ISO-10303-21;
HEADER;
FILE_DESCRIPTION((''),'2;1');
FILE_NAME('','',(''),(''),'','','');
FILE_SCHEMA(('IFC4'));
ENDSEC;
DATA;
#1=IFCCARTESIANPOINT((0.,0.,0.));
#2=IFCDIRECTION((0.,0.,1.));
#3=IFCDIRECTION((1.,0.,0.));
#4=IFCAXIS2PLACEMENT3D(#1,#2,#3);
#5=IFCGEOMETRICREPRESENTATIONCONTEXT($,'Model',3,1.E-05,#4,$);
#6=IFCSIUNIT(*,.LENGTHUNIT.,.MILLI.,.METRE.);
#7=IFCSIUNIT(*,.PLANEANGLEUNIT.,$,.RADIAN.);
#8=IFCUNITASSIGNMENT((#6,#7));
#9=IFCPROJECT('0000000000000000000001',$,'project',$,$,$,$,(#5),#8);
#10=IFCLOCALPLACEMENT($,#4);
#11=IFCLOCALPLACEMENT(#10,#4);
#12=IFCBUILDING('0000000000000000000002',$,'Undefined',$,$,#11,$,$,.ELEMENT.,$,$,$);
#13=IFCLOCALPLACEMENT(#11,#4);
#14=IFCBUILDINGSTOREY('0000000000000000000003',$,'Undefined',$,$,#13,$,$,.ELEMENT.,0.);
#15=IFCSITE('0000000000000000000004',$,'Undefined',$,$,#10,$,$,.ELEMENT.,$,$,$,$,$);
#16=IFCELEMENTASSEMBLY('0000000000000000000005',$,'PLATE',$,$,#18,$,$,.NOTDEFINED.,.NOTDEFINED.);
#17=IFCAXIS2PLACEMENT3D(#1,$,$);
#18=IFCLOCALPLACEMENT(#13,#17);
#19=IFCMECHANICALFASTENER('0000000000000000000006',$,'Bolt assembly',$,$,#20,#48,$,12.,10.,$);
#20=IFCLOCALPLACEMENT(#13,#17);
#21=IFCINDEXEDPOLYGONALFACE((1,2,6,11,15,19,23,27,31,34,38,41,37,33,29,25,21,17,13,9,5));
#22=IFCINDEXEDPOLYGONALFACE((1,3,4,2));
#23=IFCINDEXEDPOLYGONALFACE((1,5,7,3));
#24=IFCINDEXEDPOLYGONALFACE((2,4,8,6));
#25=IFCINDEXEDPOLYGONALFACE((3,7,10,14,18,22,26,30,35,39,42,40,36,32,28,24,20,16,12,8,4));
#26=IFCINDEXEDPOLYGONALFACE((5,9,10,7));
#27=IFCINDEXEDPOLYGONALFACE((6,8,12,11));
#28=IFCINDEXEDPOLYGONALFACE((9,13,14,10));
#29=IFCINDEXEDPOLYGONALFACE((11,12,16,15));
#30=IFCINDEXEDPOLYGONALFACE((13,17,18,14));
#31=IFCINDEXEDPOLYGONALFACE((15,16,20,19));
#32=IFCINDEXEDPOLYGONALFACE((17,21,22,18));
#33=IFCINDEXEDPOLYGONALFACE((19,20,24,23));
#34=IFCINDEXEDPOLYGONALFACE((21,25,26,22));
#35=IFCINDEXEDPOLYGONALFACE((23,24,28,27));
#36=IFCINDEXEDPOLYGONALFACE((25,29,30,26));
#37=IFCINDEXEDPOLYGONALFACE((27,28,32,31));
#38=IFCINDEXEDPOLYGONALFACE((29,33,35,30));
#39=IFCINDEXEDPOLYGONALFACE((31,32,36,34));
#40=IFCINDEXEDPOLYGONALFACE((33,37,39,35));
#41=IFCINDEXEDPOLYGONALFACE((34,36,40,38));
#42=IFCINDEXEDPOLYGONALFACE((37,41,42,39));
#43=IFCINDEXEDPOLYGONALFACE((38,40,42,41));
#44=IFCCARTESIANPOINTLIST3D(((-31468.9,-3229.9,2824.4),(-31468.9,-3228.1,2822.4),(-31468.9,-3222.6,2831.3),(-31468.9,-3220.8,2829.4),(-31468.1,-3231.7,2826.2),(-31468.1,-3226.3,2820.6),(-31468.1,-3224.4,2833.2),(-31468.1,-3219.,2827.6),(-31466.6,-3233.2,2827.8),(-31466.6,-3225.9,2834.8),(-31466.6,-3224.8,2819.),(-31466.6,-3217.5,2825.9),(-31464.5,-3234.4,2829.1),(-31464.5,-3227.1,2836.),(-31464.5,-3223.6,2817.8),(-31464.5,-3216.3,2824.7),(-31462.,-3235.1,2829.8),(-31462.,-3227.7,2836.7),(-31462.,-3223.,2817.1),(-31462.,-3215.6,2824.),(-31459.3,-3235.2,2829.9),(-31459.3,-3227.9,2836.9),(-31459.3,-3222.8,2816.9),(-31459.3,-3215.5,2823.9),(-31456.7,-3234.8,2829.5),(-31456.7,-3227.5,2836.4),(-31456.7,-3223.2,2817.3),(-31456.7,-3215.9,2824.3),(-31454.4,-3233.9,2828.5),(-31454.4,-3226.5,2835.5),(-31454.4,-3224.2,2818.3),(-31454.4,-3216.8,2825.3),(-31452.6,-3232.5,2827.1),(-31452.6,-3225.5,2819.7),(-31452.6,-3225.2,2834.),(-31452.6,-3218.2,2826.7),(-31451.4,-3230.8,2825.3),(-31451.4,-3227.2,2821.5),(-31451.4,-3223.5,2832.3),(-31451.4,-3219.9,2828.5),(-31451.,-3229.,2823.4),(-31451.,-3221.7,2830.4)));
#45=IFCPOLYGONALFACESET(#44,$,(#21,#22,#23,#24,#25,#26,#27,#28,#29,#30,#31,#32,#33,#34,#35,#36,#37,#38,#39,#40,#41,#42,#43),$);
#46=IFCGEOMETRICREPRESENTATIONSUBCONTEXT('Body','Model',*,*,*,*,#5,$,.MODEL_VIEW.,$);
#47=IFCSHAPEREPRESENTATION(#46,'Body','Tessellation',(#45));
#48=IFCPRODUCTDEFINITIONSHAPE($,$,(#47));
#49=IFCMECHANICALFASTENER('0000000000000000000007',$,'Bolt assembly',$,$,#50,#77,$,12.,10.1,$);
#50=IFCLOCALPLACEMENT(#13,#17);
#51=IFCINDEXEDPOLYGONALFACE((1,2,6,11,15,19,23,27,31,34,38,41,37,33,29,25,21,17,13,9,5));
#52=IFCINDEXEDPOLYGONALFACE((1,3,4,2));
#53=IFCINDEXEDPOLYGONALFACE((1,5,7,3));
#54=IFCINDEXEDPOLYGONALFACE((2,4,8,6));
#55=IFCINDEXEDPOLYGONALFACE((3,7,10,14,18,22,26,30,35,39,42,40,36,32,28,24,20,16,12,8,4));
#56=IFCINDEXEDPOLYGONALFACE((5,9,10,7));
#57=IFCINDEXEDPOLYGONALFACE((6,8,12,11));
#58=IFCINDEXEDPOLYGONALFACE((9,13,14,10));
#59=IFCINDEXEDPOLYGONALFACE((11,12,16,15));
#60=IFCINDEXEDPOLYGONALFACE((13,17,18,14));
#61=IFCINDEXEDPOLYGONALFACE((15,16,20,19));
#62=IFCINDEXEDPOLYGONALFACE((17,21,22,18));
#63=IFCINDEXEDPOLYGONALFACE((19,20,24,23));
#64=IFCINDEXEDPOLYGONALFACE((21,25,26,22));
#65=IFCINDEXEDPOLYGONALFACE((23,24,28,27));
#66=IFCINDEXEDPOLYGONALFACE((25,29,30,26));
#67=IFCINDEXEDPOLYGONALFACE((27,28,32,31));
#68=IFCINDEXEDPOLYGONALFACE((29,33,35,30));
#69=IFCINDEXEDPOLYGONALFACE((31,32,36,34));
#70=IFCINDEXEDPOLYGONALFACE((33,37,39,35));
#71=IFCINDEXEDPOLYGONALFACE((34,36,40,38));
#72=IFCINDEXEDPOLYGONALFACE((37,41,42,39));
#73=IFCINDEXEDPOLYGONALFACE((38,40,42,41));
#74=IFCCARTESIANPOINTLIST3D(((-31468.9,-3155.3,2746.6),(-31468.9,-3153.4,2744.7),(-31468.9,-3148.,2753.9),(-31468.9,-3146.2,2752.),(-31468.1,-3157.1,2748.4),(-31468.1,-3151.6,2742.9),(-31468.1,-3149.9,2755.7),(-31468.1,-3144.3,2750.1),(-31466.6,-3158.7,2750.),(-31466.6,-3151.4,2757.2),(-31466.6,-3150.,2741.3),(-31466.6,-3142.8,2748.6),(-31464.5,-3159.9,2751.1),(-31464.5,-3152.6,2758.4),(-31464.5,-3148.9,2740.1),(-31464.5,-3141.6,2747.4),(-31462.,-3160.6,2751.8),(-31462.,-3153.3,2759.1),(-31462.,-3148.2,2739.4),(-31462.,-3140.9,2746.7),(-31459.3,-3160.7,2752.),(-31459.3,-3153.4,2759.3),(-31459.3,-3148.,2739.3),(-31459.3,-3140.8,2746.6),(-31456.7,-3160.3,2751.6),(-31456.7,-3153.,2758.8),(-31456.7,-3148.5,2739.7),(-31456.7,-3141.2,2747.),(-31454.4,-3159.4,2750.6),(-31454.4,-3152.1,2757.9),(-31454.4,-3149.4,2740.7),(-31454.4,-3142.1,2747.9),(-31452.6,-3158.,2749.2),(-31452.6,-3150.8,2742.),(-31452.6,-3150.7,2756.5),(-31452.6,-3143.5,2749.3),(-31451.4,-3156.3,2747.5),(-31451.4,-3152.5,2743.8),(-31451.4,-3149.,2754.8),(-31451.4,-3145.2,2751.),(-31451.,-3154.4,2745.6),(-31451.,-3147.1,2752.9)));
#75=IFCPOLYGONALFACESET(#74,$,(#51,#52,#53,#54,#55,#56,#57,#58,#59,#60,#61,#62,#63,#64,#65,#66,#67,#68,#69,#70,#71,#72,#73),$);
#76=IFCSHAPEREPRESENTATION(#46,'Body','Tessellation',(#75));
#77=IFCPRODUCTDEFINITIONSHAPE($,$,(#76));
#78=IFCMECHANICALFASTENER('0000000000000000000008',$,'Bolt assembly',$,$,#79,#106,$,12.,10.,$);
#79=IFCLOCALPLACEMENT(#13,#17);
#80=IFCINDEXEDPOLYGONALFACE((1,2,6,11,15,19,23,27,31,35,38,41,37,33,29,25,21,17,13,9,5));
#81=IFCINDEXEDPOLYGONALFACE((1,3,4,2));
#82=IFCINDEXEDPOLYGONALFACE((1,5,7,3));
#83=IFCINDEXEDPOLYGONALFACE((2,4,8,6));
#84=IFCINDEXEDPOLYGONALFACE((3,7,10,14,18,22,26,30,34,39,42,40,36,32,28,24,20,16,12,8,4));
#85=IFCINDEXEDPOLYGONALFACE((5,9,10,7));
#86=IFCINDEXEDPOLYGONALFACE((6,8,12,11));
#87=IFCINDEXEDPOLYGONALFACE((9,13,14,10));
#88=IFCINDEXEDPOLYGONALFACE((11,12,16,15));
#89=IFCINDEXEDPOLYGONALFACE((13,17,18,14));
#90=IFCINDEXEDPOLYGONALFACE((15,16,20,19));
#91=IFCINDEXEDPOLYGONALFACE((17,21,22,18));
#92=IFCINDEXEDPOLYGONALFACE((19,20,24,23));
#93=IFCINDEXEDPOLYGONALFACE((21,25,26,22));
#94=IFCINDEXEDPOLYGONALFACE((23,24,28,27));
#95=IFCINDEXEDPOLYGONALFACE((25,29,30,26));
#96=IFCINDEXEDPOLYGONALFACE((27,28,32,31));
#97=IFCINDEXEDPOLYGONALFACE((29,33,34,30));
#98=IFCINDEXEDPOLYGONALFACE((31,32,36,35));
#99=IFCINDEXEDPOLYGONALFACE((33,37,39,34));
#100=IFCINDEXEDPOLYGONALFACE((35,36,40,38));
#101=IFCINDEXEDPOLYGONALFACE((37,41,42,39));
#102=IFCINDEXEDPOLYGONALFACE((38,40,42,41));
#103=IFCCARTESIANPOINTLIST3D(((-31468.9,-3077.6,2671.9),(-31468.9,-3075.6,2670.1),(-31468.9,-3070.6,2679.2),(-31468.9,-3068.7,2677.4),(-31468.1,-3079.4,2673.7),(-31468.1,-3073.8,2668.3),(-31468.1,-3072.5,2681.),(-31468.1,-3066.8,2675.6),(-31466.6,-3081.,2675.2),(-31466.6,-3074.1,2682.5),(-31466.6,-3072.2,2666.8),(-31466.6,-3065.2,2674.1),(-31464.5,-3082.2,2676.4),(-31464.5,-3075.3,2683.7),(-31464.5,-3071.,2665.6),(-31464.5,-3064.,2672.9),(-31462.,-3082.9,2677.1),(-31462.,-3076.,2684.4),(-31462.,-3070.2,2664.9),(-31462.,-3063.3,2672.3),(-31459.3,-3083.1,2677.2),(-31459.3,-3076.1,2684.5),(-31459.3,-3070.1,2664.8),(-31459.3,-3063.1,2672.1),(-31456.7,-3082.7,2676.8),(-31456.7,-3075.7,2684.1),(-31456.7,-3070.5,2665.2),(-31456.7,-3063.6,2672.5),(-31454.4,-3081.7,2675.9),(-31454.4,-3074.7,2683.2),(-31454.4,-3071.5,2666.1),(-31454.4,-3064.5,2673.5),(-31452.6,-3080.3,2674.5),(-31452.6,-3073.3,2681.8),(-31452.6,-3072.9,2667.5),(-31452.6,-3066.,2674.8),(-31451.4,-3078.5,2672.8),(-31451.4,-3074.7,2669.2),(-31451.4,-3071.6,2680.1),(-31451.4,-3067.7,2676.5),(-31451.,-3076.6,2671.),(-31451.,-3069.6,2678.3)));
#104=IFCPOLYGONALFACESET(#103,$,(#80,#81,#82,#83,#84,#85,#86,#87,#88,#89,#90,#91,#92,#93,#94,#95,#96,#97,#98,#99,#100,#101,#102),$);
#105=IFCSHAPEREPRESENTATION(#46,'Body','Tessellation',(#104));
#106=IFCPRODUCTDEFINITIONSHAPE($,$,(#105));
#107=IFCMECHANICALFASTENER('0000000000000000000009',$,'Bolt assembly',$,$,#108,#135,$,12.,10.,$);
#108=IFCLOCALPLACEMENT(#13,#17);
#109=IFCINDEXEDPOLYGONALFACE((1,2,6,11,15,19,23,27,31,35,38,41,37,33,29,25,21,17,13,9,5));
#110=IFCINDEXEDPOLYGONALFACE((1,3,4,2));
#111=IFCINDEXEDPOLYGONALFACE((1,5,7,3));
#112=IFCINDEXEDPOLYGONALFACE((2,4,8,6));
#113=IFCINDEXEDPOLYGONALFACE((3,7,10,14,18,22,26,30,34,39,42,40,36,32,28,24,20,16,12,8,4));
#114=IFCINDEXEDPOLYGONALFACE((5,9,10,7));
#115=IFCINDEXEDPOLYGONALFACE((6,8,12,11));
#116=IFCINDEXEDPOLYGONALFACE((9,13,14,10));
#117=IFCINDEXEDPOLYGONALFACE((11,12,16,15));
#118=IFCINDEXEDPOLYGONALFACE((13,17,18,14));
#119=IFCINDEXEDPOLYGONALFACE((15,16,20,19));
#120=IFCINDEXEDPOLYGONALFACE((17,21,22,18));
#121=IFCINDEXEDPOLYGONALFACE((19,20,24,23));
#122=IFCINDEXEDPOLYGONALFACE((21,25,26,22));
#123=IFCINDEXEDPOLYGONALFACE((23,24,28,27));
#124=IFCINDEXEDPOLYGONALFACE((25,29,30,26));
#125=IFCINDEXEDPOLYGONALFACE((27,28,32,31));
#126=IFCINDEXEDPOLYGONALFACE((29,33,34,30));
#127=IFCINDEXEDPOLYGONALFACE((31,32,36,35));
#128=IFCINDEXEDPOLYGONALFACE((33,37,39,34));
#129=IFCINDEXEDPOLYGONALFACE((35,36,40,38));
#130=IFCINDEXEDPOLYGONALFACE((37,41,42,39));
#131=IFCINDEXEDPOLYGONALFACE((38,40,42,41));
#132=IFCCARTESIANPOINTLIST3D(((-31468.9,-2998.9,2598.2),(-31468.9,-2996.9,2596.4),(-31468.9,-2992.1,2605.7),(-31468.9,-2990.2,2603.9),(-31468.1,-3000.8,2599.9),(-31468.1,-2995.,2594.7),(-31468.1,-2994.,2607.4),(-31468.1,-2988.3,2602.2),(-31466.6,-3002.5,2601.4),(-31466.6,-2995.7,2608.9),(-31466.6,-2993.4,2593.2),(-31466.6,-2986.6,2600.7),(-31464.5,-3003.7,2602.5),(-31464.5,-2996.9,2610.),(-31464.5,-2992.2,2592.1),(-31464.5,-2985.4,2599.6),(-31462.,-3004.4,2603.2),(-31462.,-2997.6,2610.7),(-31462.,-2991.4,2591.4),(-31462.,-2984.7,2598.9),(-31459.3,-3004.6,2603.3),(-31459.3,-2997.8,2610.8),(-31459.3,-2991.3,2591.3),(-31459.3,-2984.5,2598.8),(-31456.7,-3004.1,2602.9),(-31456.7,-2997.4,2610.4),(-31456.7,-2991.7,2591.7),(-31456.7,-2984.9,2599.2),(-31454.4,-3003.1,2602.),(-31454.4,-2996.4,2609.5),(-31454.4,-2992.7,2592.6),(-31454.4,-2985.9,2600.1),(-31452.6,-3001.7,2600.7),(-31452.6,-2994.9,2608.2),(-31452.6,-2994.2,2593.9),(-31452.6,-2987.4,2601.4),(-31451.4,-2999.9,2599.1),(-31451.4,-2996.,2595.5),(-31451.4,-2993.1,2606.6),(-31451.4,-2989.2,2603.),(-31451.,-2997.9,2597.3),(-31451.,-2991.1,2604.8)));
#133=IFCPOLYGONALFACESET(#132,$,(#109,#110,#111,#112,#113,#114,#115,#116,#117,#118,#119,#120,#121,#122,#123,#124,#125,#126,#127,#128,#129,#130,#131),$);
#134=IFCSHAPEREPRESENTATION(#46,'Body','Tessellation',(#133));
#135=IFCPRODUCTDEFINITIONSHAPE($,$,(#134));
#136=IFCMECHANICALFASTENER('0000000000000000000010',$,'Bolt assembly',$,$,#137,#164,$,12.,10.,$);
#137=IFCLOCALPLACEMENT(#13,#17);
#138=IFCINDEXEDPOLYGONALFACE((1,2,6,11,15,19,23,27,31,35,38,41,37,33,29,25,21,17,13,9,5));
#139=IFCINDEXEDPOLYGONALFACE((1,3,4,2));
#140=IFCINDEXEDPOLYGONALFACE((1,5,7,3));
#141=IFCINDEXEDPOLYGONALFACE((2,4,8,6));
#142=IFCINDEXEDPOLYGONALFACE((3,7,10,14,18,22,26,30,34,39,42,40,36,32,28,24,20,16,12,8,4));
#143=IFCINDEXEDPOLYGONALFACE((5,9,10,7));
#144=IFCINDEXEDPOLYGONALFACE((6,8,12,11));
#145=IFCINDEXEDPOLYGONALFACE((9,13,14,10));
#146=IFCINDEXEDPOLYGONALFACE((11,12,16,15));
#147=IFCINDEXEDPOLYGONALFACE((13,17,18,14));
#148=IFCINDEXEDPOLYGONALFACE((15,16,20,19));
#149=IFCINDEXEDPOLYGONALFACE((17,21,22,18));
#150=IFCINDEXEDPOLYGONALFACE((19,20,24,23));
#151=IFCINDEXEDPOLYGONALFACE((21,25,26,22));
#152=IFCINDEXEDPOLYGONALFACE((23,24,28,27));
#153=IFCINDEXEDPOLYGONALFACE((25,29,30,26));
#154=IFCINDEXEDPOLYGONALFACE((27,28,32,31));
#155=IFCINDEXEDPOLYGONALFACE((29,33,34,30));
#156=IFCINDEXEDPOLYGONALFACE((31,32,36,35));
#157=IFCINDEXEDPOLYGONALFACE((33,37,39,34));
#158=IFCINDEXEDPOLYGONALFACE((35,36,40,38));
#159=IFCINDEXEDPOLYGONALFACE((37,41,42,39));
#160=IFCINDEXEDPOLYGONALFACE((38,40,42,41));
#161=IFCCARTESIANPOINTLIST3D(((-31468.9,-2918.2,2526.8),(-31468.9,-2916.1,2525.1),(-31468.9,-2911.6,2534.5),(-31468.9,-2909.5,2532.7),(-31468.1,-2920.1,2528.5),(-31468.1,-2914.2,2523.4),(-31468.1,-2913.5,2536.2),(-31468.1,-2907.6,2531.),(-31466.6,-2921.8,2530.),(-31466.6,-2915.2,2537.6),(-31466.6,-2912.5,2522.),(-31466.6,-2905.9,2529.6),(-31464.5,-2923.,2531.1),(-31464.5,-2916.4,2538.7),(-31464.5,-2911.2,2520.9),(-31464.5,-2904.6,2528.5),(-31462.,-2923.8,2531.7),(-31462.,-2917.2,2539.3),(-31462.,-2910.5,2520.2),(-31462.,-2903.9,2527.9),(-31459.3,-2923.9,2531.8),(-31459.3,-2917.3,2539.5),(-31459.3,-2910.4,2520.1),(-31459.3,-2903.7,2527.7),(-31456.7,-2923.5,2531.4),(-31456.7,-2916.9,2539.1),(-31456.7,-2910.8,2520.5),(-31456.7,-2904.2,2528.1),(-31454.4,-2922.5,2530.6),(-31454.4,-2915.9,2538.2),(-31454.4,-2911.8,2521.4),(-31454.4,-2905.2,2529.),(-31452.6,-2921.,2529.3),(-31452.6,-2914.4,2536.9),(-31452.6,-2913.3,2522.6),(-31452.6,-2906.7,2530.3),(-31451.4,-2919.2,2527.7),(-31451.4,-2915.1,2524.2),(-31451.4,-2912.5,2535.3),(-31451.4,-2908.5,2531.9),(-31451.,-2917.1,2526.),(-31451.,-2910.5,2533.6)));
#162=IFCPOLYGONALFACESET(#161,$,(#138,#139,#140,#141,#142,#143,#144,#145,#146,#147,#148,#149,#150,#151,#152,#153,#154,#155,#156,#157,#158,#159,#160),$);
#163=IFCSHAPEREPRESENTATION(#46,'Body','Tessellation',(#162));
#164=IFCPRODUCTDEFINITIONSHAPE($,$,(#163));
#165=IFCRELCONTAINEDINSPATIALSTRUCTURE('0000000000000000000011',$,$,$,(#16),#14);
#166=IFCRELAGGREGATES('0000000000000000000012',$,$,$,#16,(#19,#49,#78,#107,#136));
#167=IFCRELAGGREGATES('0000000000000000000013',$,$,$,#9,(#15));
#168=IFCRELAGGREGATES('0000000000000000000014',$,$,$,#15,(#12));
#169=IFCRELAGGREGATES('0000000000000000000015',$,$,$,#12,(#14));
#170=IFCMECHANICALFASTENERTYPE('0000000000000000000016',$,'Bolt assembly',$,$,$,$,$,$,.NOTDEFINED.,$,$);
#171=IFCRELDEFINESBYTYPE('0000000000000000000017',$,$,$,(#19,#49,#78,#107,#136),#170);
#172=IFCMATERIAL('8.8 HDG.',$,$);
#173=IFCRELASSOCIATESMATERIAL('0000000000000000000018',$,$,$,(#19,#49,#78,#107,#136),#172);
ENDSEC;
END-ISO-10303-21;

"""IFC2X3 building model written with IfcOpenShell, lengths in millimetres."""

from ifc_helpers import new_model, si_unit, frame, origin_with_axes, origin_2d_with_axis, place, context, subcontext, project, spatial, circle, extrude, source, transform, mapped, material, type_object, element, aggregate, save


model = new_model("IFC2X3")

# Units and contexts
model_context = context("Model", 3, precision=1e-05, world=origin_with_axes())
body_context = subcontext(model_context, "Body", "Model", "MODEL_VIEW")
ifc_project = project(units=[si_unit("LENGTHUNIT", "METRE", prefix="MILLI"), si_unit("PLANEANGLEUNIT", "RADIAN")], contexts=[model_context])

# Site, building, storey
site_placement = place(None, origin_with_axes())
site = spatial("IfcSite", under=ifc_project, at=site_placement, Name="Undefined", CompositionType="ELEMENT")
building_placement = place(site_placement, origin_with_axes())
building = spatial("IfcBuilding", under=site, at=building_placement, Name="Undefined", CompositionType="ELEMENT")
storey_placement = place(building_placement, origin_with_axes())
storey = spatial("IfcBuildingStorey", under=building, at=storey_placement, Name="Undefined", CompositionType="ELEMENT", Elevation=0.0)

# Element assembly, mechanical fasteners
assembly_placement = place(storey_placement, origin_with_axes())
assembly = element("IfcElementAssembly", 1, at=assembly_placement, inside=storey, Name="PLATE", AssemblyPlace="NOTDEFINED", PredefinedType="NOTDEFINED")
ifc_material_1 = material(Name="8.8 HDG.")
mechanical_fastener_type = type_object("IfcMechanicalFastenerType", Name="Bolt assembly")
shared_shape_1 = source(origin_with_axes(), body_context, "Body", "SweptSolid", [
    extrude(circle(Radius=9.0, at=origin_2d_with_axis()), frame((0.0, 0.9, 0.0), z_axis=(0.0, 1.0, 0.0), x_axis=(1.0, 0.0, 0.0)), (0.0, 0.0, 1.0), 10.1),
])
mechanical_fastener_1_placement = place(assembly_placement, frame((-31460.0, -3229.7, 2822.8), z_axis=(0.000001, -0.689814, 0.723987), x_axis=(1.0, 0.000001, -0.000001)))
mechanical_fastener_1 = element("IfcMechanicalFastener", 2, at=mechanical_fastener_1_placement, type_object=mechanical_fastener_type, material=ifc_material_1, Name="Bolt assembly", NominalDiameter=12.0, NominalLength=10.0, context=body_context, shape_type="MappedRepresentation", body=[
    mapped(shared_shape_1, transform((0.0, 0.0, 0.0))),
])
shared_shape_2 = source(origin_with_axes(), body_context, "Body", "SweptSolid", [
    extrude(circle(Radius=9.0, at=origin_2d_with_axis()), frame((0.0, 0.0, 0.0), z_axis=(0.0, 1.0, 0.0), x_axis=(1.0, 0.0, 0.0)), (0.0, 0.0, 1.0), 10.3),
])
mechanical_fastener_2_placement = place(assembly_placement, frame((-31460.0, -3154.4, 2745.6), z_axis=(0.000001, -0.707107, 0.707107), x_axis=(1.0, 0.000001, -0.000001)))
mechanical_fastener_2 = element("IfcMechanicalFastener", 3, at=mechanical_fastener_2_placement, type_object=mechanical_fastener_type, material=ifc_material_1, Name="Bolt assembly", NominalDiameter=12.0, NominalLength=10.1, context=body_context, shape_type="MappedRepresentation", body=[
    mapped(shared_shape_2, transform((0.0, 0.0, 0.0))),
])
shared_shape_3 = source(origin_with_axes(), body_context, "Body", "SweptSolid", [
    extrude(circle(Radius=9.0, at=origin_2d_with_axis()), frame((0.0, 0.9, 0.0), z_axis=(0.0, 1.0, 0.0), x_axis=(1.0, 0.0, 0.0)), (0.0, 0.0, 1.0), 10.1),
])
mechanical_fastener_3_placement = place(assembly_placement, frame((-31460.0, -3077.2, 2670.3), z_axis=(0.000001, -0.723987, 0.689814), x_axis=(1.0, 0.000001, -0.000001)))
mechanical_fastener_3 = element("IfcMechanicalFastener", 4, at=mechanical_fastener_3_placement, type_object=mechanical_fastener_type, material=ifc_material_1, Name="Bolt assembly", NominalDiameter=12.0, NominalLength=10.0, context=body_context, shape_type="MappedRepresentation", body=[
    mapped(shared_shape_3, transform((0.0, 0.0, 0.0))),
])
shared_shape_4 = source(origin_with_axes(), body_context, "Body", "SweptSolid", [
    extrude(circle(Radius=9.0, at=origin_2d_with_axis()), frame((0.0, 0.5, 0.0), z_axis=(0.0, 1.0, 0.0), x_axis=(1.0, 0.0, 0.0)), (0.0, 0.0, 1.0), 10.1),
])
mechanical_fastener_4_placement = place(assembly_placement, frame((-31460.0, -2998.3, 2596.9), z_axis=(0.000001, -0.740444, 0.672118), x_axis=(1.0, 0.000001, -0.000001)))
mechanical_fastener_4 = element("IfcMechanicalFastener", 5, at=mechanical_fastener_4_placement, type_object=mechanical_fastener_type, material=ifc_material_1, Name="Bolt assembly", NominalDiameter=12.0, NominalLength=10.0, context=body_context, shape_type="MappedRepresentation", body=[
    mapped(shared_shape_4, transform((0.0, 0.0, 0.0))),
])
shared_shape_5 = source(origin_with_axes(), body_context, "Body", "SweptSolid", [
    extrude(circle(Radius=9.0, at=origin_2d_with_axis()), frame((0.0, 0.7, 0.0), z_axis=(0.0, 1.0, 0.0), x_axis=(1.0, 0.0, 0.0)), (0.0, 0.0, 1.0), 10.1),
])
mechanical_fastener_5_placement = place(assembly_placement, frame((-31460.0, -2917.6, 2525.4), z_axis=(0.000001, -0.756468, 0.65403), x_axis=(1.0, 0.000001, -0.000001)))
mechanical_fastener_5 = element("IfcMechanicalFastener", 6, at=mechanical_fastener_5_placement, type_object=mechanical_fastener_type, material=ifc_material_1, Name="Bolt assembly", NominalDiameter=12.0, NominalLength=10.0, context=body_context, shape_type="MappedRepresentation", body=[
    mapped(shared_shape_5, transform((0.0, 0.0, 0.0))),
])
aggregate(assembly, [mechanical_fastener_1, mechanical_fastener_2, mechanical_fastener_3, mechanical_fastener_4, mechanical_fastener_5])

save(model, "model.ifc")
